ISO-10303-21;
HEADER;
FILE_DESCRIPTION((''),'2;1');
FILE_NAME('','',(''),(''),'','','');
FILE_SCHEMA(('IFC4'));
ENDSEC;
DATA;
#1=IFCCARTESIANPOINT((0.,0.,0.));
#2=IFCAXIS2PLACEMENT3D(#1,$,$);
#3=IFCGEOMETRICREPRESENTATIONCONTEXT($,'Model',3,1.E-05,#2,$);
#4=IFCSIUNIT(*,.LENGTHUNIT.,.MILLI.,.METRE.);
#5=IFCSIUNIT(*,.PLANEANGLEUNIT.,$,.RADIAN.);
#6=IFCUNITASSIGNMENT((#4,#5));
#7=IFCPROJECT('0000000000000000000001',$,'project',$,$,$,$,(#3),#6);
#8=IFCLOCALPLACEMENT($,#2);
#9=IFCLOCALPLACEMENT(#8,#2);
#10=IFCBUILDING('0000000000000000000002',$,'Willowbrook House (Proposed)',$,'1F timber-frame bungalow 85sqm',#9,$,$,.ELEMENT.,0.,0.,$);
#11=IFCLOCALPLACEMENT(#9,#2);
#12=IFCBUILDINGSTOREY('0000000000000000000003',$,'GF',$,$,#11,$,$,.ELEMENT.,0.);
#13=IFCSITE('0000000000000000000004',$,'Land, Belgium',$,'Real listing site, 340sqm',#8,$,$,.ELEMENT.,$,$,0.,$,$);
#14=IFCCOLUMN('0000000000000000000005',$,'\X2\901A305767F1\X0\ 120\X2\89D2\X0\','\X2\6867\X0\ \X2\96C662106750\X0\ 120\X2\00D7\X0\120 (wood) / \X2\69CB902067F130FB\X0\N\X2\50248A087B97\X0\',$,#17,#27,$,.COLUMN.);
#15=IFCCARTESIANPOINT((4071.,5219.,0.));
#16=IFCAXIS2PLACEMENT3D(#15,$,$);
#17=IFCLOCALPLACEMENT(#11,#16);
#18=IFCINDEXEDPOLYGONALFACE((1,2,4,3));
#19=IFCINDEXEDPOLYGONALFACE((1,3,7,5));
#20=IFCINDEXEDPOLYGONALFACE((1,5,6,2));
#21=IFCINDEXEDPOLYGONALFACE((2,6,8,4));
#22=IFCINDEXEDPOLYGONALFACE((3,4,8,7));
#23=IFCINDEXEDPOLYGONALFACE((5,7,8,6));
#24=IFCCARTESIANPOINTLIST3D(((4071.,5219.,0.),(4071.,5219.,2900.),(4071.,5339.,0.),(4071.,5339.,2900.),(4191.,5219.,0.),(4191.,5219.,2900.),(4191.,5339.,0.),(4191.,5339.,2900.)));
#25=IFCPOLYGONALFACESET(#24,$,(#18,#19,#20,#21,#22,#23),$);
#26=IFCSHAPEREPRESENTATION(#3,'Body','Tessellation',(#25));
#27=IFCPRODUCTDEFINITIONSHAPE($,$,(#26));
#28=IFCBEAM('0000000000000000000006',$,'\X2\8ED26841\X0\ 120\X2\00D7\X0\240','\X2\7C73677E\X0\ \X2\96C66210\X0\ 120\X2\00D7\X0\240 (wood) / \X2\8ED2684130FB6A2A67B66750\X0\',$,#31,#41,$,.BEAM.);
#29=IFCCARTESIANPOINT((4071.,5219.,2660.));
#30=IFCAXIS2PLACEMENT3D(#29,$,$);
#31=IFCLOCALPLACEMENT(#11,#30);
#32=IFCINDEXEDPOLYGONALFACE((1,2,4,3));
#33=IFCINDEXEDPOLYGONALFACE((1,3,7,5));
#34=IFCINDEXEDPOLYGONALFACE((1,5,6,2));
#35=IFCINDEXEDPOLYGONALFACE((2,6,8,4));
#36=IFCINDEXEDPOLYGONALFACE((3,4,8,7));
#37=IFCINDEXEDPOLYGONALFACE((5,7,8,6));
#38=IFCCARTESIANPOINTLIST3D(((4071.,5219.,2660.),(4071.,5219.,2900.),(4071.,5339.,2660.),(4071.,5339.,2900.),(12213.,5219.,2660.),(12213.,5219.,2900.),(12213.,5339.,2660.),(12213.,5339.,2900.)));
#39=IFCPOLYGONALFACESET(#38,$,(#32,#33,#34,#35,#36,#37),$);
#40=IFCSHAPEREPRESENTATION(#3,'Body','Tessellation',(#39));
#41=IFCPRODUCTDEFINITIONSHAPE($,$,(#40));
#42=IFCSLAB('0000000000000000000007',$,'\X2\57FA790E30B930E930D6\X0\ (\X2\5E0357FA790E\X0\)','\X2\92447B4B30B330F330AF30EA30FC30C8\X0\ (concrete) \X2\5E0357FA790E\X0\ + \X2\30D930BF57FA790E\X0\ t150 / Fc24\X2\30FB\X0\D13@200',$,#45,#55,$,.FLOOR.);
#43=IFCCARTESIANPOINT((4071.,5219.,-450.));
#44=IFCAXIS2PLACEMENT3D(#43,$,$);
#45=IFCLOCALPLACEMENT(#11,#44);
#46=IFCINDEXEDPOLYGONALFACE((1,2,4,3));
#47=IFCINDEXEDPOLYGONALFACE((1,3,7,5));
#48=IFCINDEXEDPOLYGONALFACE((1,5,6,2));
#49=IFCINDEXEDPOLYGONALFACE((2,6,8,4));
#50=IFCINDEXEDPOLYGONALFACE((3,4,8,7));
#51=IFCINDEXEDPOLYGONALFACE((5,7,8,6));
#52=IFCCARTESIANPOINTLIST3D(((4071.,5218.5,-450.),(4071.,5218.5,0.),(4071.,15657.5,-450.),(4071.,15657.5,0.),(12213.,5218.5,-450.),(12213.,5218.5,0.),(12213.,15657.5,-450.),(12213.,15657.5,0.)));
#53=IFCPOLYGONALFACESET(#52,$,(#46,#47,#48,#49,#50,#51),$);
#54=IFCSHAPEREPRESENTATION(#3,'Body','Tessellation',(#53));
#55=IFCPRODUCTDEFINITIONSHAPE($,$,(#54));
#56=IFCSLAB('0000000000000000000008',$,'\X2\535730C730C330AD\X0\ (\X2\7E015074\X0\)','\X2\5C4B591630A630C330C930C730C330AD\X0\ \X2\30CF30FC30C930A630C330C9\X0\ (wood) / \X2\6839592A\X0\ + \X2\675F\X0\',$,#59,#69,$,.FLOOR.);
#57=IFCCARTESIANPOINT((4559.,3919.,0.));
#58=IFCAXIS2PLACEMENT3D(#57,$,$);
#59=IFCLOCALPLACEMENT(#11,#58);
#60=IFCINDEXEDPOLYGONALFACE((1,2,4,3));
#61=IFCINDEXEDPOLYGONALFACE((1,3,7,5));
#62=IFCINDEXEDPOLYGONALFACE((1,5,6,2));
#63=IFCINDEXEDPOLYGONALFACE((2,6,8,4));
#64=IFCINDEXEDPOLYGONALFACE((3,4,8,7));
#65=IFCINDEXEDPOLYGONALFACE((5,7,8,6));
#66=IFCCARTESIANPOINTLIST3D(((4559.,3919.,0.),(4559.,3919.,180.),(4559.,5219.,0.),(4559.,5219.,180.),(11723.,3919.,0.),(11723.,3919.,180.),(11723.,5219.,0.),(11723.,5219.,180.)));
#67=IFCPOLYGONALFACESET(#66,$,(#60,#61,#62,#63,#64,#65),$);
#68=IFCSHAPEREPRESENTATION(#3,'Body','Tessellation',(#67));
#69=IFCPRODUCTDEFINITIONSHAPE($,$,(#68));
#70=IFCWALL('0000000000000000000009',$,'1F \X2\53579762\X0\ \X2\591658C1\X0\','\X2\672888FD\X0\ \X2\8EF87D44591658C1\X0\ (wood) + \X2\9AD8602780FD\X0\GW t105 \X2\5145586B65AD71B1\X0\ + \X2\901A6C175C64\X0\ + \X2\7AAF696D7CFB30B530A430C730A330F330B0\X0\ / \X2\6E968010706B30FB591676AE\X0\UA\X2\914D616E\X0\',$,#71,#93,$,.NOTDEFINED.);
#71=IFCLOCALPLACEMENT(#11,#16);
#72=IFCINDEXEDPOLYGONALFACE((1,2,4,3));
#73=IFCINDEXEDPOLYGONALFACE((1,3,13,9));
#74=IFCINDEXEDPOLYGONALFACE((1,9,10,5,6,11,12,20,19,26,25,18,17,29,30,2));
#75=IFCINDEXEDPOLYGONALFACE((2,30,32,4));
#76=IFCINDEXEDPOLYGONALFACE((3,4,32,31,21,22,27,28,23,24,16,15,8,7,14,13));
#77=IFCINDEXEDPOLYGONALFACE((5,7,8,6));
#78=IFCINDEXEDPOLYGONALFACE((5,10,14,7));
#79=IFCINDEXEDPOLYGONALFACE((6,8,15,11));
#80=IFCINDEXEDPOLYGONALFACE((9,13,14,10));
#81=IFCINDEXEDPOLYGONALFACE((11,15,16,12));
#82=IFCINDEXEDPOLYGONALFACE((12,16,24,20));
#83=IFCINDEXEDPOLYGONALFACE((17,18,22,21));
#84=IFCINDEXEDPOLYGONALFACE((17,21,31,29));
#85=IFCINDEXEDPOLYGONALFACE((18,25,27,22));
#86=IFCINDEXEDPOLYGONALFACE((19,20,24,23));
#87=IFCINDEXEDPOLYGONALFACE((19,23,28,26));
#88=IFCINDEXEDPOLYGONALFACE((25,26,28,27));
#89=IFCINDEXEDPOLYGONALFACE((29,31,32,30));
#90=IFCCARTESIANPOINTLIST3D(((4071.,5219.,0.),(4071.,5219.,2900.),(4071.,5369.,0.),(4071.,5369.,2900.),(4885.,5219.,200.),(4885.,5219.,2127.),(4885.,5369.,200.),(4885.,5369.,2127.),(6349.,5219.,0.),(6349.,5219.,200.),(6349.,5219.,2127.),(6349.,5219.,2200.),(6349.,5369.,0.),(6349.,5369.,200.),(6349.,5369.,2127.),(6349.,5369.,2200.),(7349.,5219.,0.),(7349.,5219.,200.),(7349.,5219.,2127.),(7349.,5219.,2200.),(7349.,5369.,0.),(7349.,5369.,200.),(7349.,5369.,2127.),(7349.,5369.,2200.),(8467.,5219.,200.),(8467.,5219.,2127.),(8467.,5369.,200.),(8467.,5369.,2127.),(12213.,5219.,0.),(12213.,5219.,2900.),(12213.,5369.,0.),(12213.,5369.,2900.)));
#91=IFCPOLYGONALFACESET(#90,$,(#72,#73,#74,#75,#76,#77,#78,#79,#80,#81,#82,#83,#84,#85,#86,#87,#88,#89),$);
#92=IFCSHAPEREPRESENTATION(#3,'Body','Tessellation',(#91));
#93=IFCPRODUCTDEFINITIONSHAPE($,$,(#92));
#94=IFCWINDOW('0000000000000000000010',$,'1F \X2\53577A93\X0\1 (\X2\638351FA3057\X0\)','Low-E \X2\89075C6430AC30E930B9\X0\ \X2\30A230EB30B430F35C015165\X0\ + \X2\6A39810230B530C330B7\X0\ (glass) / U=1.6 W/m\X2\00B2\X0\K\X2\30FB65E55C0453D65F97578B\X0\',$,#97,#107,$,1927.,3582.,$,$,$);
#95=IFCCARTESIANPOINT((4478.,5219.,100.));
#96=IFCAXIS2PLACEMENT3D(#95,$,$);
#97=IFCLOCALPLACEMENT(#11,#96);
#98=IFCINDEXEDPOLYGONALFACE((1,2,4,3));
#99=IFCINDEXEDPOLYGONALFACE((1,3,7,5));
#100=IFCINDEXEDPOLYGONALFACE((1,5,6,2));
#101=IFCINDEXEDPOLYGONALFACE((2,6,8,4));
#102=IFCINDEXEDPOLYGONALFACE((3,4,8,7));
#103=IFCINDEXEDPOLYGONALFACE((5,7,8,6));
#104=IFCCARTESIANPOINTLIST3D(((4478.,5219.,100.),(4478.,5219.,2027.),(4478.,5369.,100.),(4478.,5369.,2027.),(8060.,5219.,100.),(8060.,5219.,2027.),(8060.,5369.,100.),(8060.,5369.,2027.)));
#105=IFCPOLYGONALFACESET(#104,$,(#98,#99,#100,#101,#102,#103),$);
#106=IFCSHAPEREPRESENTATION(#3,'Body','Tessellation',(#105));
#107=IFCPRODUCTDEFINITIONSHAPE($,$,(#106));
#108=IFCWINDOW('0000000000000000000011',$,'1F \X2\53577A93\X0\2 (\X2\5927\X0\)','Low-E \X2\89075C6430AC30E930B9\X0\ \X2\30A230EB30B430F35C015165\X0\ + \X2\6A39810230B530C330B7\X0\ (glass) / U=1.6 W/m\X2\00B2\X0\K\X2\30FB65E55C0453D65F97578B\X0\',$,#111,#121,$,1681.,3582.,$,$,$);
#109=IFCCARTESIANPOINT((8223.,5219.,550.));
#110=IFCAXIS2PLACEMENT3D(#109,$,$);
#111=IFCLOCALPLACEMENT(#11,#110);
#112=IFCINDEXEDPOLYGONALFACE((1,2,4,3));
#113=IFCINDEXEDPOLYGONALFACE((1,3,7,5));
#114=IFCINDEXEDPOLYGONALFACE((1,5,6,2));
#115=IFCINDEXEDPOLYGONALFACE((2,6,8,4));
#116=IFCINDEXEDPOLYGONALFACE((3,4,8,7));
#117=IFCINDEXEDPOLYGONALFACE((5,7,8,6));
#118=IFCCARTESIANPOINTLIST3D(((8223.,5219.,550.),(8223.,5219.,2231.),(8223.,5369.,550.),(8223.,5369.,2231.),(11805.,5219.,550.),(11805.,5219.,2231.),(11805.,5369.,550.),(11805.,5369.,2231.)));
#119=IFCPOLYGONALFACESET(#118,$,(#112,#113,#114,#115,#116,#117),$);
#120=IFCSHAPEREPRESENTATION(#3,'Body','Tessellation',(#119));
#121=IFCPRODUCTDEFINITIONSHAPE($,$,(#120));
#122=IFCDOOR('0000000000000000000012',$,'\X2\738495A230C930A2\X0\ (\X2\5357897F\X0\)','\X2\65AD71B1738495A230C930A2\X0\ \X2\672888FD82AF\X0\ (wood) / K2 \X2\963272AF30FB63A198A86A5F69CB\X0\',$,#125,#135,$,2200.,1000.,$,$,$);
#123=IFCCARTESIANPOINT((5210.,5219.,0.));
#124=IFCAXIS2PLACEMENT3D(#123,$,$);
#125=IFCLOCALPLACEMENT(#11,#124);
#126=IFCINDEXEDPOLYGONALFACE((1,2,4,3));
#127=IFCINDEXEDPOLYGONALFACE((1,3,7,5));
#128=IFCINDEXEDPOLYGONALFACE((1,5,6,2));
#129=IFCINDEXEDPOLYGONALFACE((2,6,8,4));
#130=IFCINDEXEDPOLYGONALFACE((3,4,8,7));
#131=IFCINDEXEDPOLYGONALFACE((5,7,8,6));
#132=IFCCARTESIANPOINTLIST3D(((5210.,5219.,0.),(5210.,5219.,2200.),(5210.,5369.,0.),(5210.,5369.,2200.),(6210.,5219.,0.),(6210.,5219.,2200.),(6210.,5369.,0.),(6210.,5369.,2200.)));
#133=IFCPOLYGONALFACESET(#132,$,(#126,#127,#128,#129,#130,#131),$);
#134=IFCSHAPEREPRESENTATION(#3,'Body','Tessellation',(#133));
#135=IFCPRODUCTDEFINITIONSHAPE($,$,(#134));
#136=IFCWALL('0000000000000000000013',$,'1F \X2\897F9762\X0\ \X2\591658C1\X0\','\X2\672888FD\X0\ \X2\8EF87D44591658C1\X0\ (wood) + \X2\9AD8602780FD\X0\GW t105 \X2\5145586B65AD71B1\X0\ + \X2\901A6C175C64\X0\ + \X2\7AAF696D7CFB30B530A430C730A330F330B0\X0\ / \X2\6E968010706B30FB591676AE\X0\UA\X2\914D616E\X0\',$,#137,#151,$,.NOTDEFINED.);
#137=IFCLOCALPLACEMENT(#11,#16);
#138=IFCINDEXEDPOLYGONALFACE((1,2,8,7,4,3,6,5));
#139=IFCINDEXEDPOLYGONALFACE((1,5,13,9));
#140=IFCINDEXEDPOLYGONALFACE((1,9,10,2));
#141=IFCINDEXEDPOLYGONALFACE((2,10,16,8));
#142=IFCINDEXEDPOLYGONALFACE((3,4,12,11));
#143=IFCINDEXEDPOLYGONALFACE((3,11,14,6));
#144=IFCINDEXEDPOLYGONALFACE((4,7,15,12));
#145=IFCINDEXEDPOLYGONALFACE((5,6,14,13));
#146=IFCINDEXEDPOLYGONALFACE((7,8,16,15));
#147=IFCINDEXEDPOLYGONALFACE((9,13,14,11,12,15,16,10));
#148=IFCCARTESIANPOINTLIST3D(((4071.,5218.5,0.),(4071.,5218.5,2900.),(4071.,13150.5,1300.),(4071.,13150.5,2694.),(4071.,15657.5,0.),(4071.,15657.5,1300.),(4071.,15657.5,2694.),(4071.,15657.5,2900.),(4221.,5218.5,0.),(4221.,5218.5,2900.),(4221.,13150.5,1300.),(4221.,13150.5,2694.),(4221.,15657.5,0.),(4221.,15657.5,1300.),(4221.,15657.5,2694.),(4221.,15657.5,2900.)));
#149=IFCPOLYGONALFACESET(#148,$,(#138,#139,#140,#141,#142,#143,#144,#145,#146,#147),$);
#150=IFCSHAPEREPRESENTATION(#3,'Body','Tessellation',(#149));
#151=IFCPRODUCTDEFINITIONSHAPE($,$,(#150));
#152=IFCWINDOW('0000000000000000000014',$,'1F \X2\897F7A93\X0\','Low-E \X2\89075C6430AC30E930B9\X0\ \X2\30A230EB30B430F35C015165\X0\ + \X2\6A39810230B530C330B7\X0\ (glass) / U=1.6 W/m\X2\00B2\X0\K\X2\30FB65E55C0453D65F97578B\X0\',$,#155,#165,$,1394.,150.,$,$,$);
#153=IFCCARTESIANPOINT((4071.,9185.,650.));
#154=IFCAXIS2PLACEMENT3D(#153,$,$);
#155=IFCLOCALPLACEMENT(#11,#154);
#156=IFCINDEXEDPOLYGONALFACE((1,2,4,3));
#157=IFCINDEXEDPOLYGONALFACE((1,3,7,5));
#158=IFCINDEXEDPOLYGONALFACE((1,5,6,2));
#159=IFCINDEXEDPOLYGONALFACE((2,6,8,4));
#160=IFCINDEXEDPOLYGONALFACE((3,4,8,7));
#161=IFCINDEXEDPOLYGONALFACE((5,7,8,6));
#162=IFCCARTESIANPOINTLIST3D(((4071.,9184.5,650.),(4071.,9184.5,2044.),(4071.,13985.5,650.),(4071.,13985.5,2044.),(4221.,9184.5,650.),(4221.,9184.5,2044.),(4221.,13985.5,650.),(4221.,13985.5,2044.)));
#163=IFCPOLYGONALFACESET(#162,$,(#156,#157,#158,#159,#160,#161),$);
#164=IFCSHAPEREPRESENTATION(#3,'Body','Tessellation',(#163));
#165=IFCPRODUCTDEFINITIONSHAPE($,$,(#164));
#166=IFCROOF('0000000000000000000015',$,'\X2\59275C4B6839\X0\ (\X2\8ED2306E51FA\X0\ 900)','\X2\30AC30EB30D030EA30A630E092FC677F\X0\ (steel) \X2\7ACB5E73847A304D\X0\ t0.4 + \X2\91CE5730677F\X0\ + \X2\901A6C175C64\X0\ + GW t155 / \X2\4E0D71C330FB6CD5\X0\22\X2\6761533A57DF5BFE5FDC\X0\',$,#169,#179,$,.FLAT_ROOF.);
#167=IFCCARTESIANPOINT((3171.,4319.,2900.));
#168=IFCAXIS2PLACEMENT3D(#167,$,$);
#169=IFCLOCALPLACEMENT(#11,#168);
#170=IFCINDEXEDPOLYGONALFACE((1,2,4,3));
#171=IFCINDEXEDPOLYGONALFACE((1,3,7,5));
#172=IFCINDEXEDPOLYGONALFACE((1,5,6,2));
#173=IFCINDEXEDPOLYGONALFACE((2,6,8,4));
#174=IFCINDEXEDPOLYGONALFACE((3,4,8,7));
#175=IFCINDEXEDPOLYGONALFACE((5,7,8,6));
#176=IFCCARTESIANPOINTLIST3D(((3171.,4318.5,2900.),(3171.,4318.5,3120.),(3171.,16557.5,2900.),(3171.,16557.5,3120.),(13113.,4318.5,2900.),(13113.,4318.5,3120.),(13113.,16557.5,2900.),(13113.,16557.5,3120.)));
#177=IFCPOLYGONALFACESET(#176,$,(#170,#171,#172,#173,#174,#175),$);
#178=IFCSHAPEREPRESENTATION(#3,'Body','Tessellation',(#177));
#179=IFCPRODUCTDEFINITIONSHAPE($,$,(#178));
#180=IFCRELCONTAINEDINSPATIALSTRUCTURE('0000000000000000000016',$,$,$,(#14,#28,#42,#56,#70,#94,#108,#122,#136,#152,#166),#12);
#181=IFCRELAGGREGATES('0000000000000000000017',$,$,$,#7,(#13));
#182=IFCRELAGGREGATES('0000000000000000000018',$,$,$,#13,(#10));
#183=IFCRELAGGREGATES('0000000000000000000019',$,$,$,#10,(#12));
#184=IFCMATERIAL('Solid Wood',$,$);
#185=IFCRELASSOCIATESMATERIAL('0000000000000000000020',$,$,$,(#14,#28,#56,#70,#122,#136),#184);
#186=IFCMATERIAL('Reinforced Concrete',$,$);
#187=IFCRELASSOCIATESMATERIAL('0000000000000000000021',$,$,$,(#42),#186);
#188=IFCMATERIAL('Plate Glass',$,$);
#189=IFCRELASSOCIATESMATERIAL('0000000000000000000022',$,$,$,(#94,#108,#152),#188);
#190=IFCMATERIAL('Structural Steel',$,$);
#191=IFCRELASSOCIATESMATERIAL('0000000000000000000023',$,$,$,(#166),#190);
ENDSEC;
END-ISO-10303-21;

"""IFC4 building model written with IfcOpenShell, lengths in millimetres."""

from ifc_helpers import new_model, si_unit, frame, frame_2d, origin, place, context, project, spatial, rectangle, extrude, material, element, fill, save


model = new_model("IFC4")

# Units and contexts
model_context = context("Model", 3, precision=1e-05, world=origin())
ifc_project = project(units=[si_unit("LENGTHUNIT", "METRE", prefix="MILLI"), si_unit("PLANEANGLEUNIT", "RADIAN")], contexts=[model_context])

# Site, building, storey
site_placement = place(None, origin())
site = spatial("IfcSite", under=ifc_project, at=site_placement, Name="Land, Belgium", ObjectType="Real listing site, 340sqm", CompositionType="ELEMENT", RefElevation=0.0)
building_placement = place(site_placement, origin())
building = spatial("IfcBuilding", under=site, at=building_placement, Name="Willowbrook House (Proposed)", ObjectType="1F timber-frame bungalow 85sqm", CompositionType="ELEMENT", ElevationOfRefHeight=0.0, ElevationOfTerrain=0.0)
storey_placement = place(building_placement, origin())
storey = spatial("IfcBuildingStorey", under=building, at=storey_placement, Name="GF", CompositionType="ELEMENT", Elevation=0.0)

# Column
ifc_material_1 = material(Name="Solid Wood")
column_1_placement = place(storey_placement, frame((4071.0, 5219.0, 0.0)))
element("IfcColumn", 1, at=column_1_placement, inside=storey, material=ifc_material_1, Name="通し柱 120角", Description="桧 集成材 120×120 (wood) / 構造柱・N値計算", PredefinedType="COLUMN", context=model_context, shape_type="SweptSolid", body=[
    extrude(rectangle(XDim=120.0, YDim=120.0, at=frame_2d((60.0, 60.0))), frame((4071.0, 5219.0, 0.0)), (0.0, 0.0, 1.0), 2900.0),
])

# Beam
beam_1_placement = place(storey_placement, frame((4071.0, 5219.0, 2660.0)))
element("IfcBeam", 2, at=beam_1_placement, inside=storey, material=ifc_material_1, Name="軒桁 120×240", Description="米松 集成 120×240 (wood) / 軒桁・横架材", PredefinedType="BEAM", context=model_context, shape_type="SweptSolid", body=[
    extrude(rectangle(XDim=8142.0, YDim=120.0, at=frame_2d((4071.0, 60.0))), frame((4071.0, 5219.0, 2660.0)), (0.0, 0.0, 1.0), 240.0),
])

# Slabs
ifc_material_2 = material(Name="Reinforced Concrete")
slab_1_placement = place(storey_placement, frame((4071.0, 5219.0, -450.0)))
element("IfcSlab", 3, at=slab_1_placement, inside=storey, material=ifc_material_2, Name="基礎スラブ (布基礎)", Description="鉄筋コンクリート (concrete) 布基礎 + ベタ基礎 t150 / Fc24・D13@200", PredefinedType="FLOOR", context=model_context, shape_type="SweptSolid", body=[
    extrude(rectangle(XDim=8142.0, YDim=10439.0, at=frame_2d((4071.0, 5219.0))), frame((4071.0, 5219.0, -450.0)), (0.0, 0.0, 1.0), 450.0),
])
slab_2_placement = place(storey_placement, frame((4559.0, 3919.0, 0.0)))
element("IfcSlab", 4, at=slab_2_placement, inside=storey, material=ifc_material_1, Name="南デッキ (縁側)", Description="屋外ウッドデッキ ハードウッド (wood) / 根太 + 束", PredefinedType="FLOOR", context=model_context, shape_type="SweptSolid", body=[
    extrude(rectangle(XDim=7164.0, YDim=1300.0, at=frame_2d((3582.0, 650.0))), frame((4559.0, 3919.0, 0.0)), (0.0, 0.0, 1.0), 180.0),
])

# Wall, openings, windows, door
wall_1_placement = place(storey_placement, frame((4071.0, 5219.0, 0.0)))
wall_1 = element("IfcWall", 5, at=wall_1_placement, inside=storey, material=ifc_material_1, Name="1F 南面 外壁", Description="木製 軸組外壁 (wood) + 高性能GW t105 充填断熱 + 通気層 + 窯業系サイディング / 準耐火・外皮UA配慮", PredefinedType="NOTDEFINED", context=model_context, shape_type="SweptSolid", body=[
    extrude(rectangle(XDim=8142.0, YDim=150.0, at=frame_2d((4071.0, 75.0))), frame((4071.0, 5219.0, 0.0)), (0.0, 0.0, 1.0), 2900.0),
])
opening_1_placement = place(storey_placement, frame((4478.0, 5219.0, 100.0)))
opening_1 = element("IfcOpeningElement", 6, at=opening_1_placement, cuts=wall_1, PredefinedType="NOTDEFINED", context=model_context, shape_type="SweptSolid", body=[
    extrude(rectangle(XDim=3582.0, YDim=150.0, at=frame_2d((1791.0, 75.0))), frame((4478.0, 5219.0, 100.0)), (0.0, 0.0, 1.0), 1927.0),
])
opening_2_placement = place(storey_placement, frame((8223.0, 5219.0, 550.0)))
opening_2 = element("IfcOpeningElement", 7, at=opening_2_placement, cuts=wall_1, PredefinedType="NOTDEFINED", context=model_context, shape_type="SweptSolid", body=[
    extrude(rectangle(XDim=3582.0, YDim=150.0, at=frame_2d((1791.0, 75.0))), frame((8223.0, 5219.0, 550.0)), (0.0, 0.0, 1.0), 1681.0),
])
opening_3_placement = place(storey_placement, frame((5210.0, 5219.0, 0.0)))
opening_3 = element("IfcOpeningElement", 8, at=opening_3_placement, cuts=wall_1, PredefinedType="NOTDEFINED", context=model_context, shape_type="SweptSolid", body=[
    extrude(rectangle(XDim=1000.0, YDim=150.0, at=frame_2d((500.0, 75.0))), frame((5210.0, 5219.0, 0.0)), (0.0, 0.0, 1.0), 2200.0),
])
ifc_material_3 = material(Name="Plate Glass")
window_1_placement = place(storey_placement, frame((4478.0, 5219.0, 100.0)))
window_1 = element("IfcWindow", 9, at=window_1_placement, inside=storey, material=ifc_material_3, Name="1F 南窓1 (掃出し)", Description="Low-E 複層ガラス アルゴン封入 + 樹脂サッシ (glass) / U=1.6 W/m²K・日射取得型", OverallHeight=1927.0, OverallWidth=3582.0, context=model_context, shape_type="SweptSolid", body=[
    extrude(rectangle(XDim=3582.0, YDim=150.0, at=frame_2d((1791.0, 75.0))), frame((4478.0, 5219.0, 100.0)), (0.0, 0.0, 1.0), 1927.0),
])
fill(opening_1, window_1)
window_2_placement = place(storey_placement, frame((8223.0, 5219.0, 550.0)))
window_2 = element("IfcWindow", 10, at=window_2_placement, inside=storey, material=ifc_material_3, Name="1F 南窓2 (大)", Description="Low-E 複層ガラス アルゴン封入 + 樹脂サッシ (glass) / U=1.6 W/m²K・日射取得型", OverallHeight=1681.0, OverallWidth=3582.0, context=model_context, shape_type="SweptSolid", body=[
    extrude(rectangle(XDim=3582.0, YDim=150.0, at=frame_2d((1791.0, 75.0))), frame((8223.0, 5219.0, 550.0)), (0.0, 0.0, 1.0), 1681.0),
])
fill(opening_2, window_2)
door_placement = place(storey_placement, frame((5210.0, 5219.0, 0.0)))
door = element("IfcDoor", 11, at=door_placement, inside=storey, material=ifc_material_1, Name="玄関ドア (南西)", Description="断熱玄関ドア 木製芯 (wood) / K2 防犯・採風機構", OverallHeight=2200.0, OverallWidth=1000.0, context=model_context, shape_type="SweptSolid", body=[
    extrude(rectangle(XDim=1000.0, YDim=150.0, at=frame_2d((500.0, 75.0))), frame((5210.0, 5219.0, 0.0)), (0.0, 0.0, 1.0), 2200.0),
])
fill(opening_3, door)

# Wall, opening, window
wall_2_placement = place(storey_placement, frame((4071.0, 5219.0, 0.0)))
wall_2 = element("IfcWall", 12, at=wall_2_placement, inside=storey, material=ifc_material_1, Name="1F 西面 外壁", Description="木製 軸組外壁 (wood) + 高性能GW t105 充填断熱 + 通気層 + 窯業系サイディング / 準耐火・外皮UA配慮", PredefinedType="NOTDEFINED", context=model_context, shape_type="SweptSolid", body=[
    extrude(rectangle(XDim=150.0, YDim=10439.0, at=frame_2d((75.0, 5219.0))), frame((4071.0, 5219.0, 0.0)), (0.0, 0.0, 1.0), 2900.0),
])
opening_4_placement = place(storey_placement, frame((4071.0, 9185.0, 650.0)))
opening_4 = element("IfcOpeningElement", 13, at=opening_4_placement, cuts=wall_2, PredefinedType="NOTDEFINED", context=model_context, shape_type="SweptSolid", body=[
    extrude(rectangle(XDim=150.0, YDim=4801.0, at=frame_2d((75.0, 2400.0))), frame((4071.0, 9185.0, 650.0)), (0.0, 0.0, 1.0), 1394.0),
])
window_3_placement = place(storey_placement, frame((4071.0, 9185.0, 650.0)))
window_3 = element("IfcWindow", 14, at=window_3_placement, inside=storey, material=ifc_material_3, Name="1F 西窓", Description="Low-E 複層ガラス アルゴン封入 + 樹脂サッシ (glass) / U=1.6 W/m²K・日射取得型", OverallHeight=1394.0, OverallWidth=150.0, context=model_context, shape_type="SweptSolid", body=[
    extrude(rectangle(XDim=150.0, YDim=4801.0, at=frame_2d((75.0, 2400.0))), frame((4071.0, 9185.0, 650.0)), (0.0, 0.0, 1.0), 1394.0),
])
fill(opening_4, window_3)

# Roof
ifc_material_4 = material(Name="Structural Steel")
roof_placement = place(storey_placement, frame((3171.0, 4319.0, 2900.0)))
element("IfcRoof", 15, at=roof_placement, inside=storey, material=ifc_material_4, Name="大屋根 (軒の出 900)", Description="ガルバリウム鋼板 (steel) 立平葺き t0.4 + 野地板 + 通気層 + GW t155 / 不燃・法22条区域対応", PredefinedType="FLAT_ROOF", context=model_context, shape_type="SweptSolid", body=[
    extrude(rectangle(XDim=9942.0, YDim=12239.0, at=frame_2d((4971.0, 6119.0))), frame((3171.0, 4319.0, 2900.0)), (0.0, 0.0, 1.0), 220.0),
])

save(model, "model.ifc")
